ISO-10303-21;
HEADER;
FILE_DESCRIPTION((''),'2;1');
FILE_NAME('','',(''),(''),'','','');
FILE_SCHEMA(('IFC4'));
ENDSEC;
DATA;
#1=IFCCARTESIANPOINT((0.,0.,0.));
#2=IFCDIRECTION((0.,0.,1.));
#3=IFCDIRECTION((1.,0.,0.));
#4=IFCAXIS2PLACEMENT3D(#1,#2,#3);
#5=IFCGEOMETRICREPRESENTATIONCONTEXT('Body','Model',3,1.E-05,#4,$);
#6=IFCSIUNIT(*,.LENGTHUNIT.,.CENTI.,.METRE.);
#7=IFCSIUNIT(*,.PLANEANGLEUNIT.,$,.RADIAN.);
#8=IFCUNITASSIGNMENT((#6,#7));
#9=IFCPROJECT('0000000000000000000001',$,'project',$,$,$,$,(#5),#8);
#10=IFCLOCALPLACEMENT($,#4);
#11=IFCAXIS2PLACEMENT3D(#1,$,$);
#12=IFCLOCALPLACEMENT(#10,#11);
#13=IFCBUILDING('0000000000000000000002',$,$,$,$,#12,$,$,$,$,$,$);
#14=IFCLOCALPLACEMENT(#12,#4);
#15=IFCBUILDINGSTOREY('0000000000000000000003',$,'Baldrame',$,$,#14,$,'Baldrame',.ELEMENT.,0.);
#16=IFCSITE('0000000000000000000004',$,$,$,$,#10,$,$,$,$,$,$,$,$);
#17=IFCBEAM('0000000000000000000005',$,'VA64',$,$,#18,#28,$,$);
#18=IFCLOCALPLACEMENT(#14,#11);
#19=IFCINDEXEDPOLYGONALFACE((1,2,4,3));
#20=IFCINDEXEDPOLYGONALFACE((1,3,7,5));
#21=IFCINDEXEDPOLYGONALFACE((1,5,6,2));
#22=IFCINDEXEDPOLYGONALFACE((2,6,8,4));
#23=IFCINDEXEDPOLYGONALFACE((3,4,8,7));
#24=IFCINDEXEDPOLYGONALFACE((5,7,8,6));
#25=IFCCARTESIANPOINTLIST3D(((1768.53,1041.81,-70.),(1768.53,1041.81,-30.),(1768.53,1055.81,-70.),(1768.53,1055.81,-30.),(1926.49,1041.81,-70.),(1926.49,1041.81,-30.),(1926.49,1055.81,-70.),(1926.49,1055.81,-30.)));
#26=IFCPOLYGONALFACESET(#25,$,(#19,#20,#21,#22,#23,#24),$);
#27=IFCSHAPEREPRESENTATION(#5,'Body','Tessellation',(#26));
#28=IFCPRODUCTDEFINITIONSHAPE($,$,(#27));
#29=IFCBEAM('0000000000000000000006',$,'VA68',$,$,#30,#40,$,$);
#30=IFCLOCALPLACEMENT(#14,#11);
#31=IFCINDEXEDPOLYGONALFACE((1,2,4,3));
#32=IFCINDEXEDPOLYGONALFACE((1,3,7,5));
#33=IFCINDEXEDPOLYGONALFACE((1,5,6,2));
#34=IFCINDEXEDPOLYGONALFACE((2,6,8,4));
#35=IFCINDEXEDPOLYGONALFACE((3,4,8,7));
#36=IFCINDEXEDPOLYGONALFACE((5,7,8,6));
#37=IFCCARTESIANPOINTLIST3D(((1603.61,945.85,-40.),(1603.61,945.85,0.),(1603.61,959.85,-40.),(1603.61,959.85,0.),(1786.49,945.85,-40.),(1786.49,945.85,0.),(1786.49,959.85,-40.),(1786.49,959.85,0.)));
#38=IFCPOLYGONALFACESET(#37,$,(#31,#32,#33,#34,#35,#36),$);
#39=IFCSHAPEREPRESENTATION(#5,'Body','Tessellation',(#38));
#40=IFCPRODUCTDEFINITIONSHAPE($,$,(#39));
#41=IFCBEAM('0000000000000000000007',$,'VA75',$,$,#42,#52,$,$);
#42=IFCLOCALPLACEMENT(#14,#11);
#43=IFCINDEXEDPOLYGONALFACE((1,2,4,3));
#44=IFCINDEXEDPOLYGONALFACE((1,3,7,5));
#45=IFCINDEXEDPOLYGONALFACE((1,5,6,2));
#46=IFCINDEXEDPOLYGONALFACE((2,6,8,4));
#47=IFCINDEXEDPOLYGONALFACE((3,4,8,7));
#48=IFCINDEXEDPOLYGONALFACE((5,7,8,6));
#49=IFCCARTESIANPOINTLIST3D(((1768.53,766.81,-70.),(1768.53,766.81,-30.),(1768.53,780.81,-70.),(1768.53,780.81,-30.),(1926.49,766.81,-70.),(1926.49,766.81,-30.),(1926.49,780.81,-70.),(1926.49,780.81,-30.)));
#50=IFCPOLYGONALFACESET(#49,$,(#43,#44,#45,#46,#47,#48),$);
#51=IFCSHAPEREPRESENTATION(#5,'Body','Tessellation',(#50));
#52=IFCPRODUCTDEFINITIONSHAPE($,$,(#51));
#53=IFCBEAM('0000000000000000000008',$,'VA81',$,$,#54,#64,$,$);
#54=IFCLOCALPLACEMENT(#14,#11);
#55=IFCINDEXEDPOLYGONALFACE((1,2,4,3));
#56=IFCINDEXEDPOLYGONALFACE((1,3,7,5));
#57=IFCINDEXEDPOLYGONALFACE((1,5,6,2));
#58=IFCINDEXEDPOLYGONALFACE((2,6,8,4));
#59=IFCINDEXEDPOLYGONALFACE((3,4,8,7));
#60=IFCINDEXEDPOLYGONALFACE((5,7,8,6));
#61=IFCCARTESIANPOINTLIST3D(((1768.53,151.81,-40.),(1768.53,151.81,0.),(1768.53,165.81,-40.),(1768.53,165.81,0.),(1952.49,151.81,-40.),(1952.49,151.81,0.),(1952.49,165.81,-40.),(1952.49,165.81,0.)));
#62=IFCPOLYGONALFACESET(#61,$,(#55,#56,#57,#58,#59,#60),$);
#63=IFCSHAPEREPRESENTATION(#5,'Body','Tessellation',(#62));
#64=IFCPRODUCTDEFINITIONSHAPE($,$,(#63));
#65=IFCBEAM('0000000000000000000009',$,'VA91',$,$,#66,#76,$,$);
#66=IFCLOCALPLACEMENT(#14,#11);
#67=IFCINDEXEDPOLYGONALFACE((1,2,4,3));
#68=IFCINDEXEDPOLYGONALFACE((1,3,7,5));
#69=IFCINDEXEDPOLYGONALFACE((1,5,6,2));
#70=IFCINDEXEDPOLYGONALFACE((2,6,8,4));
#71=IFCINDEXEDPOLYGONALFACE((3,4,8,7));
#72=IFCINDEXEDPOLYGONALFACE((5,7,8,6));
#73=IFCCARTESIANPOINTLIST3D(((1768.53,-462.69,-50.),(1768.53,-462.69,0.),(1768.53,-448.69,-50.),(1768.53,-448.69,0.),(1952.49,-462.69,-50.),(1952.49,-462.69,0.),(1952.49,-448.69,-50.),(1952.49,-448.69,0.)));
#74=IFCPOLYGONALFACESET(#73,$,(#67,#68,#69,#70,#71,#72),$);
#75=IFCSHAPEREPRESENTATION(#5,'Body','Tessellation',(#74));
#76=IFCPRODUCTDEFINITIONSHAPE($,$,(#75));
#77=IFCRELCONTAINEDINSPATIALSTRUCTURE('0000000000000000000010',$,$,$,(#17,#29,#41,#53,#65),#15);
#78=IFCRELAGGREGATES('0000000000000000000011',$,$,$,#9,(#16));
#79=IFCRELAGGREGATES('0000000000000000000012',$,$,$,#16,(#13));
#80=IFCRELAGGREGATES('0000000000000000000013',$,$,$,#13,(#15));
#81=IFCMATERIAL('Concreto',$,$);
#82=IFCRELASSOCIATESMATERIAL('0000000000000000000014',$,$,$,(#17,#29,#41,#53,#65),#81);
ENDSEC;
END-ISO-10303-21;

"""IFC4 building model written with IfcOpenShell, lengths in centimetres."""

from ifc_helpers import new_model, si_unit, frame, origin, origin_with_axes, origin_2d_with_axis, place, context, project, spatial, rectangle, extrude, material, element, save


model = new_model("IFC4")

# Units and contexts
model_context = context("Model", 3, precision=1e-05, world=origin_with_axes(), identifier="Body")
ifc_project = project(units=[si_unit("LENGTHUNIT", "METRE", prefix="CENTI"), si_unit("PLANEANGLEUNIT", "RADIAN")], contexts=[model_context])

# Site, building, storey
site_placement = place(None, origin_with_axes())
site = spatial("IfcSite", under=ifc_project, at=site_placement)
building_placement = place(site_placement, origin())
building = spatial("IfcBuilding", under=site, at=building_placement)
storey_placement = place(building_placement, origin_with_axes())
storey = spatial("IfcBuildingStorey", under=building, at=storey_placement, Name="Baldrame", LongName="Baldrame", CompositionType="ELEMENT", Elevation=0.0)

# Shared definitions
ifc_material = material(Name="Concreto")

# Beams
beam_1_placement = place(storey_placement, frame((1847.51, 1048.81, -30.0), z_axis=(0.0, 0.0, 1.0), x_axis=(1.0, 0.0, 0.0)))
element("IfcBeam", 1, at=beam_1_placement, inside=storey, material=ifc_material, Name="VA64", context=model_context, shape_type="SolidModel", body=[
    extrude(rectangle(XDim=14.0, YDim=40.0, at=origin_2d_with_axis()), frame((-78.98, 0.0, -20.0), z_axis=(1.0, 0.0, 0.0), x_axis=(0.0, 1.0, 0.0)), (0.0, 0.0, 1.0), 157.96),
])
beam_2_placement = place(storey_placement, frame((1695.05, 952.85, 0.0), z_axis=(0.0, 0.0, 1.0), x_axis=(1.0, 0.0, 0.0)))
element("IfcBeam", 2, at=beam_2_placement, inside=storey, material=ifc_material, Name="VA68", context=model_context, shape_type="SolidModel", body=[
    extrude(rectangle(XDim=14.0, YDim=40.0, at=origin_2d_with_axis()), frame((-91.44, 0.0, -20.0), z_axis=(1.0, 0.0, 0.0), x_axis=(0.0, 1.0, 0.0)), (0.0, 0.0, 1.0), 182.88),
])
beam_3_placement = place(storey_placement, frame((1847.51, 773.81, -30.0), z_axis=(0.0, 0.0, 1.0), x_axis=(1.0, 0.0, 0.0)))
element("IfcBeam", 3, at=beam_3_placement, inside=storey, material=ifc_material, Name="VA75", context=model_context, shape_type="SolidModel", body=[
    extrude(rectangle(XDim=14.0, YDim=40.0, at=origin_2d_with_axis()), frame((-78.98, 0.0, -20.0), z_axis=(1.0, 0.0, 0.0), x_axis=(0.0, 1.0, 0.0)), (0.0, 0.0, 1.0), 157.96),
])
beam_4_placement = place(storey_placement, frame((1860.51, 158.81, 0.0), z_axis=(0.0, 0.0, 1.0), x_axis=(1.0, 0.0, 0.0)))
element("IfcBeam", 4, at=beam_4_placement, inside=storey, material=ifc_material, Name="VA81", context=model_context, shape_type="SolidModel", body=[
    extrude(rectangle(XDim=14.0, YDim=40.0, at=origin_2d_with_axis()), frame((-91.98, 0.0, -20.0), z_axis=(1.0, 0.0, 0.0), x_axis=(0.0, 1.0, 0.0)), (0.0, 0.0, 1.0), 183.96),
])
beam_5_placement = place(storey_placement, frame((1860.51, -455.69, 0.0), z_axis=(0.0, 0.0, 1.0), x_axis=(1.0, 0.0, 0.0)))
element("IfcBeam", 5, at=beam_5_placement, inside=storey, material=ifc_material, Name="VA91", context=model_context, shape_type="SolidModel", body=[
    extrude(rectangle(XDim=14.0, YDim=50.0, at=origin_2d_with_axis()), frame((-91.98, 0.0, -25.0), z_axis=(1.0, 0.0, 0.0), x_axis=(0.0, 1.0, 0.0)), (0.0, 0.0, 1.0), 183.96),
])

save(model, "model.ifc")
